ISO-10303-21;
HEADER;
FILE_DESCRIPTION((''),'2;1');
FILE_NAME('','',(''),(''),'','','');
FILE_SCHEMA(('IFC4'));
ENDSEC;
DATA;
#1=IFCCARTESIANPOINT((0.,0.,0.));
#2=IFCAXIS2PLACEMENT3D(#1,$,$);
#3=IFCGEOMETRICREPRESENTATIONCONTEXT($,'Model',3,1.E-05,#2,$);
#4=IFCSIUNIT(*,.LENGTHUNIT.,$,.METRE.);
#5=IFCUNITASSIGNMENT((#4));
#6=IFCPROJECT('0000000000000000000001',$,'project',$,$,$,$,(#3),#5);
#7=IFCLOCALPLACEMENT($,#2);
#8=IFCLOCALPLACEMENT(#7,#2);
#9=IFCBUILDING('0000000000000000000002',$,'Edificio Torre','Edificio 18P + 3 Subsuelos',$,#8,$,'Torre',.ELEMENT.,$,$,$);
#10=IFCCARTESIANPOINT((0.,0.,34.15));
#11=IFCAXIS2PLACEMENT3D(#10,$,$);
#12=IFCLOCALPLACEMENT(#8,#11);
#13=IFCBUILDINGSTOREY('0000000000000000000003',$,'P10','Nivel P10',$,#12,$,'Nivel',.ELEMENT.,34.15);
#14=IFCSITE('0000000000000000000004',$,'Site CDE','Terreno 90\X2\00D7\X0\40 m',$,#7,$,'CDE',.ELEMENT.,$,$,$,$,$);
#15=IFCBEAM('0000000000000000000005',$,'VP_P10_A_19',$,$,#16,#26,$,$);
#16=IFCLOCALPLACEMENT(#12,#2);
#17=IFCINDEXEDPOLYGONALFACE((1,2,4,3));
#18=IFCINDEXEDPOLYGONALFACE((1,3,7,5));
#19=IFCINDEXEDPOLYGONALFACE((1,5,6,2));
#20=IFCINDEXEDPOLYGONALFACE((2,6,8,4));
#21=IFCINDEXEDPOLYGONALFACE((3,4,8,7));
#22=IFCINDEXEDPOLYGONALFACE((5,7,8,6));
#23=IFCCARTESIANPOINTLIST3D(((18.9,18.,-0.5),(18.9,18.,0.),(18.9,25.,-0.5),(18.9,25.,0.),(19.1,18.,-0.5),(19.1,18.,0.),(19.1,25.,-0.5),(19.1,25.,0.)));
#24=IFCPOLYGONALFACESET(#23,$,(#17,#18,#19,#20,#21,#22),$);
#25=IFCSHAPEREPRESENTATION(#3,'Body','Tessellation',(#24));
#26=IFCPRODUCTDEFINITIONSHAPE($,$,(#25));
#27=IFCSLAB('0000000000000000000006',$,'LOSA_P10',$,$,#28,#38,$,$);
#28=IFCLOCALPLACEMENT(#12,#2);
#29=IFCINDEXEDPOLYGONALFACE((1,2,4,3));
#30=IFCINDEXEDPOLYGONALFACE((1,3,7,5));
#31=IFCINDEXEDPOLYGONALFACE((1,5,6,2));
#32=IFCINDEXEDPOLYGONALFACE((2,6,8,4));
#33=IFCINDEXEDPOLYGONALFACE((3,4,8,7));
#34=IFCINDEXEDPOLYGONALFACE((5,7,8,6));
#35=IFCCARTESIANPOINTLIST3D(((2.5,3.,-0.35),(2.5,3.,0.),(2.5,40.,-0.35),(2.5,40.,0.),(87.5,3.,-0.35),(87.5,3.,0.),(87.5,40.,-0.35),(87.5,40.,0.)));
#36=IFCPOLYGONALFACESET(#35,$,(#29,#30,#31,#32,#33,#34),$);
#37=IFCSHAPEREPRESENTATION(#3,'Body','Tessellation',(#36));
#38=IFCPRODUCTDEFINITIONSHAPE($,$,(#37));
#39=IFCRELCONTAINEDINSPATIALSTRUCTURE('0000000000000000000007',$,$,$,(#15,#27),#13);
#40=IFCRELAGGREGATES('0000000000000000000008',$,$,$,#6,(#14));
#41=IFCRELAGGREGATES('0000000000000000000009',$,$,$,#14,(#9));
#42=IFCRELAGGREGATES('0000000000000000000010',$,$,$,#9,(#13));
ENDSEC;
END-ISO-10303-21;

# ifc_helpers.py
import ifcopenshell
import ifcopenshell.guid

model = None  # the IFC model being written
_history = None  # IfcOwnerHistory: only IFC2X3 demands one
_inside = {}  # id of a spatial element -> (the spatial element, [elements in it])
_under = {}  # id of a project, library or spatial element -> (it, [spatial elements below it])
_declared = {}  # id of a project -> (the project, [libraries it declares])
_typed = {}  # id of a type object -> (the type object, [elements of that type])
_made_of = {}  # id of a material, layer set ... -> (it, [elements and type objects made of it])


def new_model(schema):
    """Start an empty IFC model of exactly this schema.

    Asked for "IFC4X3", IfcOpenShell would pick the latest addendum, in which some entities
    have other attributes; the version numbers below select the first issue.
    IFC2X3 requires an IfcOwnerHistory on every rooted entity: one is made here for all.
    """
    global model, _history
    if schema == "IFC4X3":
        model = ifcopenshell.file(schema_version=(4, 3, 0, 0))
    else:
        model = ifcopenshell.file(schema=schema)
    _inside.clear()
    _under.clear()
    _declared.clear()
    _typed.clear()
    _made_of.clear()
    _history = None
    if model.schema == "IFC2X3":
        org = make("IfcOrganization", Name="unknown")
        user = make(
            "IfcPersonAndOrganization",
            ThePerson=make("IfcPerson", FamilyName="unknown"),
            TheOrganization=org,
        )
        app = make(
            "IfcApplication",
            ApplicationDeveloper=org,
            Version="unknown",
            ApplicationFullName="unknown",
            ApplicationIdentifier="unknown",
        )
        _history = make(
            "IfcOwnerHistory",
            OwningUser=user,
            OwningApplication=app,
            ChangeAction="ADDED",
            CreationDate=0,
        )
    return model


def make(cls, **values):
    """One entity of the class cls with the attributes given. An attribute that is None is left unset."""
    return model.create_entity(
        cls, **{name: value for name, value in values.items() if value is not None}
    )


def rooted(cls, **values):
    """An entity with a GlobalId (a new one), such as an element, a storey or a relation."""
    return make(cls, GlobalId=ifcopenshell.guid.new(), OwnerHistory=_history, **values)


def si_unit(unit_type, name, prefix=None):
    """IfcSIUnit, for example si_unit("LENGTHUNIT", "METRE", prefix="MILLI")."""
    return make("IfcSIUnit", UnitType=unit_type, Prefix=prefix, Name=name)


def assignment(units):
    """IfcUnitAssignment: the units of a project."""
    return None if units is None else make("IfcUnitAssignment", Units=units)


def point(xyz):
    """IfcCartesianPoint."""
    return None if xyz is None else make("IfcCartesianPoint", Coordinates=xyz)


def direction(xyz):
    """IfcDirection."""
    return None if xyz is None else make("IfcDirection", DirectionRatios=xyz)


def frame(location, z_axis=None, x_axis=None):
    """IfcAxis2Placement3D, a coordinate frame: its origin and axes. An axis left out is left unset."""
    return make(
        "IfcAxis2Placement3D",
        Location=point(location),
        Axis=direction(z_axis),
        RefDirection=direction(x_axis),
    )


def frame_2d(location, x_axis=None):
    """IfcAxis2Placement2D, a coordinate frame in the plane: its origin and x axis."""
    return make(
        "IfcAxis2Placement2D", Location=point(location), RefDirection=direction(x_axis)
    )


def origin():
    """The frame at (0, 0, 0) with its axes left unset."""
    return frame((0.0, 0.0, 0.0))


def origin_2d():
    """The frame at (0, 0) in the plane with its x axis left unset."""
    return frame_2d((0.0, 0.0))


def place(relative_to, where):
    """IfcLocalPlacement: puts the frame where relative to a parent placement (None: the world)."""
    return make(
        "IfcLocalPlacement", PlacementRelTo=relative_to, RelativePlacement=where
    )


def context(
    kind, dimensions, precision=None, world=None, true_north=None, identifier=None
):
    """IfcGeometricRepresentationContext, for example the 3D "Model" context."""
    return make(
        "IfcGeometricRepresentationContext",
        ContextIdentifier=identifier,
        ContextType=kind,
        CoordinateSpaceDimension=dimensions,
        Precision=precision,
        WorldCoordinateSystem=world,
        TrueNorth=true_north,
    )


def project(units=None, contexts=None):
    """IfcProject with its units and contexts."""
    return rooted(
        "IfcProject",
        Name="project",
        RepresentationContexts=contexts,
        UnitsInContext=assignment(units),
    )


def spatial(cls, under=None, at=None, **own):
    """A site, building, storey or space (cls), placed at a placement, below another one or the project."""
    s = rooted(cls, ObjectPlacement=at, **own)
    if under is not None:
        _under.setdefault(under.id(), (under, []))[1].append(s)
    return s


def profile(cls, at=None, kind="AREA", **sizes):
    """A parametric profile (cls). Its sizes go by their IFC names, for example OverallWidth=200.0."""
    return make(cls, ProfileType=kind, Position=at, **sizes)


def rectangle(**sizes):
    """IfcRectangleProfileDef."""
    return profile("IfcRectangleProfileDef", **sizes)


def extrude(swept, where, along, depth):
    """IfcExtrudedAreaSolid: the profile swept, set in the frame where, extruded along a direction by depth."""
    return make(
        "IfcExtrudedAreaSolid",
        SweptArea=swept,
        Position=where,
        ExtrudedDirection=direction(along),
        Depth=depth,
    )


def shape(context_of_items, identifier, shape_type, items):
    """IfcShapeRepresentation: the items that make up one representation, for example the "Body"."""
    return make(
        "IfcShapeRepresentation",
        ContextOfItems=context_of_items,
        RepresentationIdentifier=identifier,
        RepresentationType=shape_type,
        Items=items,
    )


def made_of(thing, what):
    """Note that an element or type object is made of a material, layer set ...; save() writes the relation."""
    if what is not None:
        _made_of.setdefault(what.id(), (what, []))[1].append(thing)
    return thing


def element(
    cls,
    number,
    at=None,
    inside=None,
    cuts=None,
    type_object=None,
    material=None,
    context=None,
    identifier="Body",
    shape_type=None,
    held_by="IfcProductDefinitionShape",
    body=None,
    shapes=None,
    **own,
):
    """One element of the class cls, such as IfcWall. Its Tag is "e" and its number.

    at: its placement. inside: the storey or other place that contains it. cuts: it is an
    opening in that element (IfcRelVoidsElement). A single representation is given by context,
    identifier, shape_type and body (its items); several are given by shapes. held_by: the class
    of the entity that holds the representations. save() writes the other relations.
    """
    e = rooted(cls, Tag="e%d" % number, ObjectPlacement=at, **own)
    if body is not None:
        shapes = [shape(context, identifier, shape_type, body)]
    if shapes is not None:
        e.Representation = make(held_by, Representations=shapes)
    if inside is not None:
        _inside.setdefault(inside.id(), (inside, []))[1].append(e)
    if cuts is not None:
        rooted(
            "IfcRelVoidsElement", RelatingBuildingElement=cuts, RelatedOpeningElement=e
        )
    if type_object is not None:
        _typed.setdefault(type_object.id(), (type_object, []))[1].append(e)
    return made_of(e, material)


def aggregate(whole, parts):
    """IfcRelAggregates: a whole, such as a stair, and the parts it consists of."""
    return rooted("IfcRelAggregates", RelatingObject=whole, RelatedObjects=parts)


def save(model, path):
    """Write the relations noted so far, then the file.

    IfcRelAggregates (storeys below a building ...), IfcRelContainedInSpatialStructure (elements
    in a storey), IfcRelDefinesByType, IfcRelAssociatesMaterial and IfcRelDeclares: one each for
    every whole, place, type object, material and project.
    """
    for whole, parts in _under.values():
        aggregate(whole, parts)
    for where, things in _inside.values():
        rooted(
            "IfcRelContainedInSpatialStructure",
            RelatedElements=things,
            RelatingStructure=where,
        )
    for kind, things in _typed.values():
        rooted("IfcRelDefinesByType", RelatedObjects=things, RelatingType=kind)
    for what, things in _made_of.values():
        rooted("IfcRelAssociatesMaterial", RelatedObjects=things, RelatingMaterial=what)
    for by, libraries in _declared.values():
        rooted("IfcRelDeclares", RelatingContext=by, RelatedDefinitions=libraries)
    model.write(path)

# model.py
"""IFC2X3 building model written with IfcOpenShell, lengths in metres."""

from ifc_helpers import new_model, si_unit, frame, origin, origin_2d, place, context, project, spatial, rectangle, extrude, element, save


model = new_model("IFC2X3")

# Units and contexts
model_context = context("Model", 3, precision=1e-05, world=origin())
ifc_project = project(units=[si_unit("LENGTHUNIT", "METRE")], contexts=[model_context])

# Site, building, storey
site_placement = place(None, origin())
site = spatial("IfcSite", under=ifc_project, at=site_placement, Name="Site CDE", Description="Terreno 90×40 m", LongName="CDE", CompositionType="ELEMENT")
building_placement = place(site_placement, origin())
building = spatial("IfcBuilding", under=site, at=building_placement, Name="Edificio Torre", Description="Edificio 18P + 3 Subsuelos", LongName="Torre", CompositionType="ELEMENT")
storey_placement = place(building_placement, frame((0.0, 0.0, 34.15)))
storey = spatial("IfcBuildingStorey", under=building, at=storey_placement, Name="P10", Description="Nivel P10", LongName="Nivel", CompositionType="ELEMENT", Elevation=34.15)

# Beam
beam_1_placement = place(storey_placement, frame((19.0, 21.5, -0.5)))
element("IfcBeam", 1, at=beam_1_placement, inside=storey, Name="VP_P10_A_19", context=model_context, shape_type="SweptSolid", body=[
    extrude(rectangle(XDim=0.2, YDim=7.0, at=origin_2d()), origin(), (0.0, 0.0, 1.0), 0.5),
])

# Slab
slab_placement = place(storey_placement, frame((45.0, 21.5, -0.35)))
element("IfcSlab", 2, at=slab_placement, inside=storey, Name="LOSA_P10", context=model_context, shape_type="SweptSolid", body=[
    extrude(rectangle(XDim=85.0, YDim=37.0, at=origin_2d()), origin(), (0.0, 0.0, 1.0), 0.35),
])

save(model, "model.ifc")
